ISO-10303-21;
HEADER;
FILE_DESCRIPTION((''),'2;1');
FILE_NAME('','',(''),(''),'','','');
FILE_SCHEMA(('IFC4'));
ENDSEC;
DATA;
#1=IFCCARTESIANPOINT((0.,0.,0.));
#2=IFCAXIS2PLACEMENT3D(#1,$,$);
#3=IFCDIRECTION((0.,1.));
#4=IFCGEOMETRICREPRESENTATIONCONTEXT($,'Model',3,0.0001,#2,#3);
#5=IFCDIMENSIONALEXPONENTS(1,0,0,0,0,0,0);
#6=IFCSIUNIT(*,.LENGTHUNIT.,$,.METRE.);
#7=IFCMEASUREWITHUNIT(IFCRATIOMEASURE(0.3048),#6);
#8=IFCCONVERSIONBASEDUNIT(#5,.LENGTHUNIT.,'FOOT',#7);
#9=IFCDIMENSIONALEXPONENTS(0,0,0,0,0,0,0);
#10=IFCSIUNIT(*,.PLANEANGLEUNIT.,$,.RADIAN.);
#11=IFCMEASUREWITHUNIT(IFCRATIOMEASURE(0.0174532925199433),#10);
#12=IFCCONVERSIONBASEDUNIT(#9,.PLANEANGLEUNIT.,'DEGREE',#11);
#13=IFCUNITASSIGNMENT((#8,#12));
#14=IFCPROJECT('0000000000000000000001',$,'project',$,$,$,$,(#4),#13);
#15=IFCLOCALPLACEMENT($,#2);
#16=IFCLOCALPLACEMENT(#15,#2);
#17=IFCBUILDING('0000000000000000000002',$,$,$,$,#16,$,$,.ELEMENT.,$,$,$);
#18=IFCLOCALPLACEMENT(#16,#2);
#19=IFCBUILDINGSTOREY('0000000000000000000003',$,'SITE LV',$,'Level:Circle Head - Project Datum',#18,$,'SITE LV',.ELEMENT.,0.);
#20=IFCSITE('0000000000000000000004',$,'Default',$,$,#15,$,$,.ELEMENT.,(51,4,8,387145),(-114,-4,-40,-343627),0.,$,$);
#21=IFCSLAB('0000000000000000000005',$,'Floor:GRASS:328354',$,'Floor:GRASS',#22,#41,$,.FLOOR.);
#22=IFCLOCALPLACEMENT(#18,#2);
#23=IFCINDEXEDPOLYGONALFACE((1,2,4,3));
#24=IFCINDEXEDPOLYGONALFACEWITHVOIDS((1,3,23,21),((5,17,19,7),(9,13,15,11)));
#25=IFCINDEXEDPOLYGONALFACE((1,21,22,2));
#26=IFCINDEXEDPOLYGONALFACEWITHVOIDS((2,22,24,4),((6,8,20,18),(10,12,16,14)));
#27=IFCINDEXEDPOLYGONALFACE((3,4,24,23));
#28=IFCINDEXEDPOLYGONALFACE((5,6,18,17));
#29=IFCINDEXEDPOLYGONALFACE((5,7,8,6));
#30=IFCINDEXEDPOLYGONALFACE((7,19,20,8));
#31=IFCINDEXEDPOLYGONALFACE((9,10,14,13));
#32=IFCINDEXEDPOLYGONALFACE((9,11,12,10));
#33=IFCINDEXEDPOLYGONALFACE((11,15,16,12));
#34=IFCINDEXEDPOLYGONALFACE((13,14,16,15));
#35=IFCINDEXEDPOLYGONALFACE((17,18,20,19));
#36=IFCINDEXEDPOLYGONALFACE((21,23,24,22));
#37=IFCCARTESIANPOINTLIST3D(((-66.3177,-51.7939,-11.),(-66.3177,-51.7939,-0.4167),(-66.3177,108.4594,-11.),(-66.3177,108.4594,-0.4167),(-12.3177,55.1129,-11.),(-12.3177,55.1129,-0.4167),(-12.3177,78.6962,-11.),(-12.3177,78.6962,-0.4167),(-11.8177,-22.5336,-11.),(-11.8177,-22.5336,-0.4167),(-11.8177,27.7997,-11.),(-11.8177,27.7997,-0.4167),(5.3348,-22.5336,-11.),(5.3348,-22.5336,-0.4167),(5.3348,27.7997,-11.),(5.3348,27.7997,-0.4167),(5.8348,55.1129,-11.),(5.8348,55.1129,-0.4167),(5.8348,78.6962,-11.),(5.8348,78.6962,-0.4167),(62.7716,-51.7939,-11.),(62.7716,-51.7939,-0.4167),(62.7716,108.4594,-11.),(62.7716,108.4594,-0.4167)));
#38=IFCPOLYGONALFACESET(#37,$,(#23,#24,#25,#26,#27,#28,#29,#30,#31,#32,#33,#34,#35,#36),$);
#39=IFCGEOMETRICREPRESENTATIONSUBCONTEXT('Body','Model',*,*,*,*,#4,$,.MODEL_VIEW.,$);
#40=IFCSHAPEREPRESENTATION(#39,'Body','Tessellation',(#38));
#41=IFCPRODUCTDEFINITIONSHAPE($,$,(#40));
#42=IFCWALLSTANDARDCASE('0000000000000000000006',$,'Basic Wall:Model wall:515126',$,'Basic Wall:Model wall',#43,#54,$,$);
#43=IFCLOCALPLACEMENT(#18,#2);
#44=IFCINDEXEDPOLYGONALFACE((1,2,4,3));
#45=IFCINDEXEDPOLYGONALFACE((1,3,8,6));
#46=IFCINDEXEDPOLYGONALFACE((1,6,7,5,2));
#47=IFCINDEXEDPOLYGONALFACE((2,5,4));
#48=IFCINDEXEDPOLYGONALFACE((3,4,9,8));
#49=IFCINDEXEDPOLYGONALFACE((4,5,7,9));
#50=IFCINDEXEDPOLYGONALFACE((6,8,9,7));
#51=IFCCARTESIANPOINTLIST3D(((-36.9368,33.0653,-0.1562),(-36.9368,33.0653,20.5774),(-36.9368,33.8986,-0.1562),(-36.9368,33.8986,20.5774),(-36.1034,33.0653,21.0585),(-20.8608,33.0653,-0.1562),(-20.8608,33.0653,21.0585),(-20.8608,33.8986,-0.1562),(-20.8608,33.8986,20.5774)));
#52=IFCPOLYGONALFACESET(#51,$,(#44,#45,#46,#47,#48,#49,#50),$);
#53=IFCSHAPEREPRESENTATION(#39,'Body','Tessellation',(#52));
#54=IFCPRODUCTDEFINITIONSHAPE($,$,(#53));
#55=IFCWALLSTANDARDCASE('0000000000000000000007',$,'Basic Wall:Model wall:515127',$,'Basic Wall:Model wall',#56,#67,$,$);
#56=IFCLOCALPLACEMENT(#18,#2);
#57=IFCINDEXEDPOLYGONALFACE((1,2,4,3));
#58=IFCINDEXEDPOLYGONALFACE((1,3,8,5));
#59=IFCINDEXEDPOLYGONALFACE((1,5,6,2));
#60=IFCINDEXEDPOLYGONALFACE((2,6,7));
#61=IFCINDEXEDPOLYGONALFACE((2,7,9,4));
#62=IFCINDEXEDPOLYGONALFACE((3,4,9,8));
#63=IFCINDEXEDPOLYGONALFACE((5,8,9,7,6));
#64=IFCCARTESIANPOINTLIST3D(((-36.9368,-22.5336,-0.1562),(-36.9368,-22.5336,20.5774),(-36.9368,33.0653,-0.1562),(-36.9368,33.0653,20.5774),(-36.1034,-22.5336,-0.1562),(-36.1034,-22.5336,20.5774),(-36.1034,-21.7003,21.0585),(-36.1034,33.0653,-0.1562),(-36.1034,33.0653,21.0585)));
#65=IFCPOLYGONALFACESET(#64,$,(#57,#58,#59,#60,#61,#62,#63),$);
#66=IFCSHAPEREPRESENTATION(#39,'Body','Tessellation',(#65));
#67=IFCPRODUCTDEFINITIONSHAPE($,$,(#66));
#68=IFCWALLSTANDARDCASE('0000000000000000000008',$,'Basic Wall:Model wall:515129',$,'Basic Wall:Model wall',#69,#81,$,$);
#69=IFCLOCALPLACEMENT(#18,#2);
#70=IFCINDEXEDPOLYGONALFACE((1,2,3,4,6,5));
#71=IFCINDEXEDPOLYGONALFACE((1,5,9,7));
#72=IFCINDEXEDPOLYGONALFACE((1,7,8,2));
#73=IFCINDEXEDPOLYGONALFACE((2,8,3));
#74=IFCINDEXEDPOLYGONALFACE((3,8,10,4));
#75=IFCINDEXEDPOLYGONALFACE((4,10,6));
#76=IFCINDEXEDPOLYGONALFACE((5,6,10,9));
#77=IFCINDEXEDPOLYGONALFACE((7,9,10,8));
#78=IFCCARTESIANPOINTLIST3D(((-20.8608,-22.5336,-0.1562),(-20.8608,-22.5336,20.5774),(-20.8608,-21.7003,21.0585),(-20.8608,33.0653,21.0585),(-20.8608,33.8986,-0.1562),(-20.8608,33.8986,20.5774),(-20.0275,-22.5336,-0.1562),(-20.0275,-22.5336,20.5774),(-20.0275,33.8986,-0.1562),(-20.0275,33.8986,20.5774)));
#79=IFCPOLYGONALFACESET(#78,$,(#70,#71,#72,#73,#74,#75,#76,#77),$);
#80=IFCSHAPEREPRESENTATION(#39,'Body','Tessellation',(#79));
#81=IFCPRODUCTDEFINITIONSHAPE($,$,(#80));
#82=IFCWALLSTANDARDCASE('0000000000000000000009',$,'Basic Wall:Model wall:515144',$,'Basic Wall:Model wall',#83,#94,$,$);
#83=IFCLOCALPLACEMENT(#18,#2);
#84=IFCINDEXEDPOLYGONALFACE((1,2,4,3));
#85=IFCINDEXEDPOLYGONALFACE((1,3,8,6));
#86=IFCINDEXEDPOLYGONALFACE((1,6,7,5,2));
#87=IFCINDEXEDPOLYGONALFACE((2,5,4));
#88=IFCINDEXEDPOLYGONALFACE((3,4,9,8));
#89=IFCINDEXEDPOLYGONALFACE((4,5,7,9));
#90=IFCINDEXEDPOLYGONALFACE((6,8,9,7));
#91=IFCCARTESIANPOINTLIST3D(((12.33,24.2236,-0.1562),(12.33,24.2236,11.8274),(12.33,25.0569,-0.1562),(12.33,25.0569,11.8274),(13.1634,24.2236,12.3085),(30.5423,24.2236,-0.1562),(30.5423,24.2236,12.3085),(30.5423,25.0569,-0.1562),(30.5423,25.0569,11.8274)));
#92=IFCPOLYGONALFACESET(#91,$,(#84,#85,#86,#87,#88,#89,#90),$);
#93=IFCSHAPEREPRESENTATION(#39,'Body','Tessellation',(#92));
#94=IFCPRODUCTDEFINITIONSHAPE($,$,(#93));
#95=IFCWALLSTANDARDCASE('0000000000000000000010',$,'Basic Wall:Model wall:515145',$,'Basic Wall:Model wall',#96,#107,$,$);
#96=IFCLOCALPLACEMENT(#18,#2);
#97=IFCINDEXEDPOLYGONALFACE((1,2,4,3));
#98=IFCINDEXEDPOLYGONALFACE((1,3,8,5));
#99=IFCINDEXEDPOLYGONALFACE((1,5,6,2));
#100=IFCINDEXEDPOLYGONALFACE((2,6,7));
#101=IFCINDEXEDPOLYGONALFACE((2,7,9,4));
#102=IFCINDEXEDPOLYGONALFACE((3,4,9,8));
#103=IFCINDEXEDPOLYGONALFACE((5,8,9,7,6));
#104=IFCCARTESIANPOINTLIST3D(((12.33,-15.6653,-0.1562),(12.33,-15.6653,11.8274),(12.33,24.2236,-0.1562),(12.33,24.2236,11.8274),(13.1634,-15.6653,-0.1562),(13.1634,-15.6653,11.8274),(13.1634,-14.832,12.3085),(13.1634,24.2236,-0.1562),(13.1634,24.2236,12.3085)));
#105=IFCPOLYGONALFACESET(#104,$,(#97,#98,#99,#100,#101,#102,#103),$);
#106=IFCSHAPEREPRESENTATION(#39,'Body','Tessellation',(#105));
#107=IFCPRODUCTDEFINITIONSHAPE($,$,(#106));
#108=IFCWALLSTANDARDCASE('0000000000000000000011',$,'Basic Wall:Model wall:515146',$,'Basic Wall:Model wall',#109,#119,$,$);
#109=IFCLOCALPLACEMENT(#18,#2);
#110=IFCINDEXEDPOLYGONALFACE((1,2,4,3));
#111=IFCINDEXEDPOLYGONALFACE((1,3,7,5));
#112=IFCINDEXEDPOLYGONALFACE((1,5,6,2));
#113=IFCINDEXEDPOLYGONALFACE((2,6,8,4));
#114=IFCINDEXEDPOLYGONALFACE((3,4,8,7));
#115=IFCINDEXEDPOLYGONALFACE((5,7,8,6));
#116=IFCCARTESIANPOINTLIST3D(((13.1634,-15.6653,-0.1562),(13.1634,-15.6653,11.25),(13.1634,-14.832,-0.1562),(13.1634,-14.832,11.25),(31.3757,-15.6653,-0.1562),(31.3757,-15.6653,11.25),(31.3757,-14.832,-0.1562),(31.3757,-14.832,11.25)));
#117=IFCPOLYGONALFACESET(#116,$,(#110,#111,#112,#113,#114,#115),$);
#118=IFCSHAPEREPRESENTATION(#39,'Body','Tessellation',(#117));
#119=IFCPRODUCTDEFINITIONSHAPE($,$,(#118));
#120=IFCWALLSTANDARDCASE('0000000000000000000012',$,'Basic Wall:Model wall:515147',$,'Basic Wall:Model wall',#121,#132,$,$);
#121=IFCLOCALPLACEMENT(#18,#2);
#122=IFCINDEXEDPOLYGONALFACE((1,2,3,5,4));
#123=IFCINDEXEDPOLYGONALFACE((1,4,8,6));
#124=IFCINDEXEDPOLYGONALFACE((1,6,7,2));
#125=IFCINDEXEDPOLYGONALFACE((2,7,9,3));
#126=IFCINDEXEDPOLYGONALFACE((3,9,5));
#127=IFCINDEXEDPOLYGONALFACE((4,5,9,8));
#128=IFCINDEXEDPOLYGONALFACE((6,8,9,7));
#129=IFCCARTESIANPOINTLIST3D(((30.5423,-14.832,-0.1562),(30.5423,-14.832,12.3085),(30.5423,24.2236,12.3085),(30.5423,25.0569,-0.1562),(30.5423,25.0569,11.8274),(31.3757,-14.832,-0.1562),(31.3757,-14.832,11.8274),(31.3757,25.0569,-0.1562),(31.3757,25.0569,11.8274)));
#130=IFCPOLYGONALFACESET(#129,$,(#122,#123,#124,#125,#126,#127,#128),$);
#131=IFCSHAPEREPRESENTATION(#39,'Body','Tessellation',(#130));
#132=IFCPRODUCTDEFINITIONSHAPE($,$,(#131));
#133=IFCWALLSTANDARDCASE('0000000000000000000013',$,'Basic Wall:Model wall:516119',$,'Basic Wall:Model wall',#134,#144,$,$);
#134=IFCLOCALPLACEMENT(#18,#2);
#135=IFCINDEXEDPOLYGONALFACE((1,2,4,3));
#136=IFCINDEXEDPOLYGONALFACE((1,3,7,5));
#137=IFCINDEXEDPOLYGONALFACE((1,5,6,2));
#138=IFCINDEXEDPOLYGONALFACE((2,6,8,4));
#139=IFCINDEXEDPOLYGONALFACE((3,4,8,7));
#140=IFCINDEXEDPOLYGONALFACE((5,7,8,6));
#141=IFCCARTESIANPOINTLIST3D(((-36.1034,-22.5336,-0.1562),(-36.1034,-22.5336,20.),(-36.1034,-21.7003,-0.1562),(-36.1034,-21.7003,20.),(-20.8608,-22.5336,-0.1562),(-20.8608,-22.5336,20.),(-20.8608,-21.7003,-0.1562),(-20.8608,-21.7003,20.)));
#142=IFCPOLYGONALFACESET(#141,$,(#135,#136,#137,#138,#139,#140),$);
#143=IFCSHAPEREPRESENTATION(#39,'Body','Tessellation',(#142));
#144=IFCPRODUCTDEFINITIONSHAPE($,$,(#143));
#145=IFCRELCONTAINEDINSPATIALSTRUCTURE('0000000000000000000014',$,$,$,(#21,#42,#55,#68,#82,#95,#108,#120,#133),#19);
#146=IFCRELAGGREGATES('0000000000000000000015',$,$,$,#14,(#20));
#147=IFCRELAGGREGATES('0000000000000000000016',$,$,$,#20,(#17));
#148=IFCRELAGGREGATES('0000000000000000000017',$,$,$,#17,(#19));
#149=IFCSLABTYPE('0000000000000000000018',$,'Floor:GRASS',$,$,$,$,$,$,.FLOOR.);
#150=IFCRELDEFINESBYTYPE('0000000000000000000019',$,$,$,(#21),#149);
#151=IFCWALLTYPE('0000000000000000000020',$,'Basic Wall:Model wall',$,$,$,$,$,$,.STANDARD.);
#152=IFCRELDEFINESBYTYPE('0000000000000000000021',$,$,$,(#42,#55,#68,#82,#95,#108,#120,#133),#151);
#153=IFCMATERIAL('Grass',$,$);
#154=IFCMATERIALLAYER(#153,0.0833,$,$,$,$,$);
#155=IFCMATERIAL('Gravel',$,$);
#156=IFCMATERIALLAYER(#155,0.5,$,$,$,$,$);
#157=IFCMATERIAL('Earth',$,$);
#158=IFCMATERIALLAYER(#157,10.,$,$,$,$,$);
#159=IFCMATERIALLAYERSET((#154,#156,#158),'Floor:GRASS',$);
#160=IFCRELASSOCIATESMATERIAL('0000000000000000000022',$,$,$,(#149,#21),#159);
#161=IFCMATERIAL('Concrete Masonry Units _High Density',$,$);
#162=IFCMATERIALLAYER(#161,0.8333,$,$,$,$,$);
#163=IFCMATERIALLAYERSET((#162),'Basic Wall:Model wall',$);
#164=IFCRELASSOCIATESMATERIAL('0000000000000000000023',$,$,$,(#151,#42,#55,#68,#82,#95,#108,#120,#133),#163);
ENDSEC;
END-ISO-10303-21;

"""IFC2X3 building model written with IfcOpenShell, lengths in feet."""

from ifc_helpers import new_model, entity, si_unit, converted_unit, direction, frame, frame_2d, origin, origin_2d_with_axis, place, context, subcontext, project, spatial, polyline, rectangle, extrude, clip, bounded_halfspace, material, layer, layer_set, layer_usage, type_object, element, save


model = new_model("IFC2X3")

# Units and contexts
model_context = context("Model", 3, precision=0.0001, world=origin(), true_north=direction((0.0, 1.0)))
body_context = subcontext(model_context, "Body", "Model", "MODEL_VIEW")
ifc_project = project(units=[converted_unit("LENGTHUNIT", "FOOT", entity("IfcRatioMeasure", 0.3048), si_unit("LENGTHUNIT", "METRE"), dimensions=[1, 0, 0, 0, 0, 0, 0]), converted_unit("PLANEANGLEUNIT", "DEGREE", entity("IfcRatioMeasure", 0.0174532925199433), si_unit("PLANEANGLEUNIT", "RADIAN"), dimensions=[0, 0, 0, 0, 0, 0, 0])], contexts=[model_context])

# Site, building, storey
site_placement = place(None, origin())
site = spatial("IfcSite", under=ifc_project, at=site_placement, Name="Default", CompositionType="ELEMENT", RefLatitude=(51, 4, 8, 387145), RefLongitude=(-114, -4, -40, -343627), RefElevation=0.0)
building_placement = place(site_placement, origin())
building = spatial("IfcBuilding", under=site, at=building_placement, CompositionType="ELEMENT")
storey_placement = place(building_placement, origin())
storey = spatial("IfcBuildingStorey", under=building, at=storey_placement, Name="SITE LV", ObjectType="Level:Circle Head - Project Datum", LongName="SITE LV", CompositionType="ELEMENT", Elevation=0.0)

# Slab, openings
ifc_material_1 = material(Name="Grass")
ifc_layer_1 = layer(ifc_material_1, 0.0833)
ifc_material_2 = material(Name="Gravel")
ifc_layer_2 = layer(ifc_material_2, 0.5)
ifc_material_3 = material(Name="Earth")
ifc_layer_3 = layer(ifc_material_3, 10.0)
ifc_layer_set_1 = layer_set([ifc_layer_1, ifc_layer_2, ifc_layer_3], Name="Floor:GRASS")
ifc_layer_usage_1 = layer_usage(ifc_layer_set_1, "AXIS3", "POSITIVE", 0.0)
slab_type_1 = type_object("IfcSlabType", Name="Floor:GRASS", PredefinedType="FLOOR", material=ifc_layer_set_1)
slab_1_placement = place(storey_placement, frame((-66.3177, -51.7939, -11.0)))
slab_1 = element("IfcSlab", 1, at=slab_1_placement, inside=storey, type_object=slab_type_1, material=ifc_layer_usage_1, Name="Floor:GRASS:328354", ObjectType="Floor:GRASS", PredefinedType="FLOOR", context=body_context, shape_type="SweptSolid", body=[
    extrude(rectangle(XDim=160.2533, YDim=129.0893, at=frame_2d((0.0, 0.0), x_axis=(0.0, -1.0))), frame((64.5447, 80.1266, 10.5833), z_axis=(0.0, 0.0, -1.0), x_axis=(-1.0, 0.0, 0.0)), (0.0, 0.0, 1.0), 10.5833),
])
opening_1_placement = place(slab_1_placement, frame((63.0762, 54.427, 10.5833)))
element("IfcOpeningElement", 2, at=opening_1_placement, cuts=slab_1, ObjectType="Opening", context=body_context, shape_type="SweptSolid", body=[
    extrude(rectangle(XDim=50.3333, YDim=17.1525, at=origin_2d_with_axis()), frame((0.0, 0.0, 0.0), z_axis=(0.0, 0.0, -1.0), x_axis=(0.0, -1.0, 0.0)), (0.0, 0.0, 1.0), 10.5833),
])
opening_2_placement = place(slab_1_placement, frame((63.0762, 118.6984, 10.5833)))
element("IfcOpeningElement", 3, at=opening_2_placement, cuts=slab_1, ObjectType="Opening", context=body_context, shape_type="SweptSolid", body=[
    extrude(rectangle(XDim=23.5833, YDim=18.1525, at=origin_2d_with_axis()), frame((0.0, 0.0, 0.0), z_axis=(0.0, 0.0, -1.0), x_axis=(0.0, -1.0, 0.0)), (0.0, 0.0, 1.0), 10.5833),
])

# Walls
ifc_material_4 = material(Name="Concrete Masonry Units _High Density")
ifc_layer_4 = layer(ifc_material_4, 0.8333)
ifc_layer_set_2 = layer_set([ifc_layer_4], Name="Basic Wall:Model wall")
ifc_layer_usage_2 = layer_usage(ifc_layer_set_2, "AXIS2", "NEGATIVE", 0.4167)
wall_type = type_object("IfcWallType", Name="Basic Wall:Model wall", PredefinedType="STANDARD", material=ifc_layer_set_2)
wall_1_placement = place(storey_placement, frame((-36.9368, 33.482, -0.1562)))
element("IfcWallStandardCase", 4, at=wall_1_placement, inside=storey, type_object=wall_type, material=ifc_layer_usage_2, Name="Basic Wall:Model wall:515126", ObjectType="Basic Wall:Model wall", context=body_context, shape_type="Clipping", body=[
    clip(clip(extrude(rectangle(XDim=16.076, YDim=0.8333, at=frame_2d((8.038, 0.0), x_axis=(-1.0, 0.0))), origin(), (0.0, 0.0, 1.0), 21.2147), bounded_halfspace(frame((0.8333, -0.4167, 21.2147), z_axis=(0.0, 0.5, 0.866025), x_axis=(-1.0, 0.0, 0.0)), False, frame((0.8333, -0.4167, 21.2147)), polyline([(0.0, 0.0), (15.2426, 0.0), (15.2426, 0.8333), (-0.8333, 0.8333), (0.0, 0.0)]))), bounded_halfspace(frame((0.0, -0.4167, 20.7335), z_axis=(-0.5, 0.0, 0.866025), x_axis=(0.0, -1.0, 0.0)), False, frame((0.0, -0.4167, 20.7335)), polyline([(0.0, 0.0), (0.8333, 0.0), (0.0, 0.8333), (0.0, 0.0)]))),
])
ifc_layer_usage_3 = layer_usage(ifc_layer_set_2, "AXIS2", "NEGATIVE", 0.4167)
wall_2_placement = place(storey_placement, frame((-36.5201, -22.5336, -0.1562), z_axis=(0.0, 0.0, 1.0), x_axis=(0.0, 1.0, 0.0)))
element("IfcWallStandardCase", 5, at=wall_2_placement, inside=storey, type_object=wall_type, material=ifc_layer_usage_3, Name="Basic Wall:Model wall:515127", ObjectType="Basic Wall:Model wall", context=body_context, shape_type="Clipping", body=[
    clip(clip(extrude(rectangle(XDim=55.5989, YDim=0.8333, at=frame_2d((27.7995, 0.0), x_axis=(-1.0, 0.0))), origin(), (0.0, 0.0, 1.0), 21.2147), bounded_halfspace(frame((0.8333, -0.4167, 21.2147), z_axis=(0.0, 0.5, 0.866025), x_axis=(-1.0, 0.0, 0.0)), False, frame((0.8333, -0.4167, 21.2147)), polyline([(0.0, 0.0), (54.7656, 0.0), (54.7656, 0.8333), (-0.8333, 0.8333), (0.0, 0.0)]))), bounded_halfspace(frame((0.0, -0.4167, 20.7335), z_axis=(-0.5, 0.0, 0.866025), x_axis=(0.0, -1.0, 0.0)), False, frame((0.0, -0.4167, 20.7335)), polyline([(0.0, 0.0), (0.8333, 0.0), (0.0, 0.8333), (0.0, 0.0)]))),
])
ifc_layer_usage_4 = layer_usage(ifc_layer_set_2, "AXIS2", "NEGATIVE", 0.4167)
wall_3_placement = place(storey_placement, frame((-20.4441, 33.8986, -0.1562), z_axis=(0.0, 0.0, 1.0), x_axis=(0.0, -1.0, 0.0)))
element("IfcWallStandardCase", 6, at=wall_3_placement, inside=storey, type_object=wall_type, material=ifc_layer_usage_4, Name="Basic Wall:Model wall:515129", ObjectType="Basic Wall:Model wall", context=body_context, shape_type="Clipping", body=[
    clip(clip(clip(extrude(rectangle(XDim=56.4323, YDim=0.8333, at=frame_2d((28.2161, 0.0), x_axis=(-1.0, 0.0))), origin(), (0.0, 0.0, 1.0), 21.2147), bounded_halfspace(frame((0.0, -0.4167, 20.7335), z_axis=(-0.5, 0.0, 0.866025), x_axis=(0.0, -1.0, 0.0)), False, frame((0.0, -0.4167, 20.7335)), polyline([(0.0, 0.0), (0.8333, 0.0), (0.0, 0.8333), (0.0, 0.0)]))), bounded_halfspace(frame((0.8333, -0.4167, 21.2147), z_axis=(0.0, 0.5, 0.866025), x_axis=(-1.0, 0.0, 0.0)), False, frame((0.8333, -0.4167, 21.2147)), polyline([(0.0, 0.0), (54.7656, 0.0), (55.5989, 0.8333), (-0.8333, 0.8333), (0.0, 0.0)]))), bounded_halfspace(frame((55.5989, -0.4167, 21.2147), z_axis=(0.5, 0.0, 0.866025), x_axis=(0.0, 1.0, 0.0)), False, frame((55.5989, -0.4167, 21.2147)), polyline([(0.0, 0.0), (0.8333, 0.0), (0.8333, 0.8333), (0.0, 0.0)]))),
])
ifc_layer_usage_5 = layer_usage(ifc_layer_set_2, "AXIS2", "NEGATIVE", 0.4167)
wall_4_placement = place(storey_placement, frame((12.33, 24.6403, -0.1562)))
element("IfcWallStandardCase", 7, at=wall_4_placement, inside=storey, type_object=wall_type, material=ifc_layer_usage_5, Name="Basic Wall:Model wall:515144", ObjectType="Basic Wall:Model wall", context=body_context, shape_type="Clipping", body=[
    clip(clip(extrude(rectangle(XDim=18.2123, YDim=0.8333, at=frame_2d((9.1061, 0.0), x_axis=(-1.0, 0.0))), origin(), (0.0, 0.0, 1.0), 12.4647), bounded_halfspace(frame((0.8333, -0.4167, 12.4647), z_axis=(0.0, 0.5, 0.866025), x_axis=(-1.0, 0.0, 0.0)), False, frame((0.8333, -0.4167, 12.4647)), polyline([(0.0, 0.0), (17.3789, 0.0), (17.3789, 0.8333), (-0.8333, 0.8333), (0.0, 0.0)]))), bounded_halfspace(frame((0.0, -0.4167, 11.9835), z_axis=(-0.5, 0.0, 0.866025), x_axis=(0.0, -1.0, 0.0)), False, frame((0.0, -0.4167, 11.9835)), polyline([(0.0, 0.0), (0.8333, 0.0), (0.0, 0.8333), (0.0, 0.0)]))),
])
ifc_layer_usage_6 = layer_usage(ifc_layer_set_2, "AXIS2", "NEGATIVE", 0.4167)
wall_5_placement = place(storey_placement, frame((12.7467, -15.6653, -0.1562), z_axis=(0.0, 0.0, 1.0), x_axis=(0.0, 1.0, 0.0)))
element("IfcWallStandardCase", 8, at=wall_5_placement, inside=storey, type_object=wall_type, material=ifc_layer_usage_6, Name="Basic Wall:Model wall:515145", ObjectType="Basic Wall:Model wall", context=body_context, shape_type="Clipping", body=[
    clip(clip(extrude(rectangle(XDim=39.8889, YDim=0.8333, at=frame_2d((19.9444, 0.0), x_axis=(-1.0, 0.0))), origin(), (0.0, 0.0, 1.0), 12.4647), bounded_halfspace(frame((0.8333, -0.4167, 12.4647), z_axis=(0.0, 0.5, 0.866025), x_axis=(-1.0, 0.0, 0.0)), False, frame((0.8333, -0.4167, 12.4647)), polyline([(0.0, 0.0), (39.0556, 0.0), (39.0556, 0.8333), (-0.8333, 0.8333), (0.0, 0.0)]))), bounded_halfspace(frame((0.0, -0.4167, 11.9835), z_axis=(-0.5, 0.0, 0.866025), x_axis=(0.0, -1.0, 0.0)), False, frame((0.0, -0.4167, 11.9835)), polyline([(0.0, 0.0), (0.8333, 0.0), (0.0, 0.8333), (0.0, 0.0)]))),
])
ifc_layer_usage_7 = layer_usage(ifc_layer_set_2, "AXIS2", "NEGATIVE", 0.4167)
wall_6_placement = place(storey_placement, frame((31.3757, -15.2486, -0.1562), z_axis=(0.0, 0.0, 1.0), x_axis=(-1.0, 0.0, 0.0)))
element("IfcWallStandardCase", 9, at=wall_6_placement, inside=storey, type_object=wall_type, material=ifc_layer_usage_7, Name="Basic Wall:Model wall:515146", ObjectType="Basic Wall:Model wall", context=body_context, shape_type="SweptSolid", body=[
    extrude(rectangle(XDim=18.2123, YDim=0.8333, at=frame_2d((9.1061, 0.0), x_axis=(-1.0, 0.0))), origin(), (0.0, 0.0, 1.0), 11.4062),
])
ifc_layer_usage_8 = layer_usage(ifc_layer_set_2, "AXIS2", "NEGATIVE", 0.4167)
wall_7_placement = place(storey_placement, frame((30.959, 25.0569, -0.1562), z_axis=(0.0, 0.0, 1.0), x_axis=(0.0, -1.0, 0.0)))
element("IfcWallStandardCase", 10, at=wall_7_placement, inside=storey, type_object=wall_type, material=ifc_layer_usage_8, Name="Basic Wall:Model wall:515147", ObjectType="Basic Wall:Model wall", context=body_context, shape_type="Clipping", body=[
    clip(clip(extrude(rectangle(XDim=39.8889, YDim=0.8333, at=frame_2d((19.9444, 0.0), x_axis=(-1.0, 0.0))), origin(), (0.0, 0.0, 1.0), 12.4647), bounded_halfspace(frame((0.0, -0.4167, 11.9835), z_axis=(-0.5, 0.0, 0.866025), x_axis=(0.0, -1.0, 0.0)), False, frame((0.0, -0.4167, 11.9835)), polyline([(0.0, 0.0), (0.8333, 0.0), (0.0, 0.8333), (0.0, 0.0)]))), bounded_halfspace(frame((0.8333, -0.4167, 12.4647), z_axis=(0.0, 0.5, 0.866025), x_axis=(-1.0, 0.0, 0.0)), False, frame((0.8333, -0.4167, 12.4647)), polyline([(0.0, 0.0), (39.0556, 0.0), (39.0556, 0.8333), (-0.8333, 0.8333), (0.0, 0.0)]))),
])
ifc_layer_usage_9 = layer_usage(ifc_layer_set_2, "AXIS2", "NEGATIVE", 0.4167)
wall_8_placement = place(storey_placement, frame((-36.1034, -22.117, -0.1562)))
element("IfcWallStandardCase", 11, at=wall_8_placement, inside=storey, type_object=wall_type, material=ifc_layer_usage_9, Name="Basic Wall:Model wall:516119", ObjectType="Basic Wall:Model wall", context=body_context, shape_type="SweptSolid", body=[
    extrude(rectangle(XDim=15.2426, YDim=0.8333, at=frame_2d((7.6213, 0.0), x_axis=(-1.0, 0.0))), origin(), (0.0, 0.0, 1.0), 20.1562),
])

save(model, "model.ifc")
